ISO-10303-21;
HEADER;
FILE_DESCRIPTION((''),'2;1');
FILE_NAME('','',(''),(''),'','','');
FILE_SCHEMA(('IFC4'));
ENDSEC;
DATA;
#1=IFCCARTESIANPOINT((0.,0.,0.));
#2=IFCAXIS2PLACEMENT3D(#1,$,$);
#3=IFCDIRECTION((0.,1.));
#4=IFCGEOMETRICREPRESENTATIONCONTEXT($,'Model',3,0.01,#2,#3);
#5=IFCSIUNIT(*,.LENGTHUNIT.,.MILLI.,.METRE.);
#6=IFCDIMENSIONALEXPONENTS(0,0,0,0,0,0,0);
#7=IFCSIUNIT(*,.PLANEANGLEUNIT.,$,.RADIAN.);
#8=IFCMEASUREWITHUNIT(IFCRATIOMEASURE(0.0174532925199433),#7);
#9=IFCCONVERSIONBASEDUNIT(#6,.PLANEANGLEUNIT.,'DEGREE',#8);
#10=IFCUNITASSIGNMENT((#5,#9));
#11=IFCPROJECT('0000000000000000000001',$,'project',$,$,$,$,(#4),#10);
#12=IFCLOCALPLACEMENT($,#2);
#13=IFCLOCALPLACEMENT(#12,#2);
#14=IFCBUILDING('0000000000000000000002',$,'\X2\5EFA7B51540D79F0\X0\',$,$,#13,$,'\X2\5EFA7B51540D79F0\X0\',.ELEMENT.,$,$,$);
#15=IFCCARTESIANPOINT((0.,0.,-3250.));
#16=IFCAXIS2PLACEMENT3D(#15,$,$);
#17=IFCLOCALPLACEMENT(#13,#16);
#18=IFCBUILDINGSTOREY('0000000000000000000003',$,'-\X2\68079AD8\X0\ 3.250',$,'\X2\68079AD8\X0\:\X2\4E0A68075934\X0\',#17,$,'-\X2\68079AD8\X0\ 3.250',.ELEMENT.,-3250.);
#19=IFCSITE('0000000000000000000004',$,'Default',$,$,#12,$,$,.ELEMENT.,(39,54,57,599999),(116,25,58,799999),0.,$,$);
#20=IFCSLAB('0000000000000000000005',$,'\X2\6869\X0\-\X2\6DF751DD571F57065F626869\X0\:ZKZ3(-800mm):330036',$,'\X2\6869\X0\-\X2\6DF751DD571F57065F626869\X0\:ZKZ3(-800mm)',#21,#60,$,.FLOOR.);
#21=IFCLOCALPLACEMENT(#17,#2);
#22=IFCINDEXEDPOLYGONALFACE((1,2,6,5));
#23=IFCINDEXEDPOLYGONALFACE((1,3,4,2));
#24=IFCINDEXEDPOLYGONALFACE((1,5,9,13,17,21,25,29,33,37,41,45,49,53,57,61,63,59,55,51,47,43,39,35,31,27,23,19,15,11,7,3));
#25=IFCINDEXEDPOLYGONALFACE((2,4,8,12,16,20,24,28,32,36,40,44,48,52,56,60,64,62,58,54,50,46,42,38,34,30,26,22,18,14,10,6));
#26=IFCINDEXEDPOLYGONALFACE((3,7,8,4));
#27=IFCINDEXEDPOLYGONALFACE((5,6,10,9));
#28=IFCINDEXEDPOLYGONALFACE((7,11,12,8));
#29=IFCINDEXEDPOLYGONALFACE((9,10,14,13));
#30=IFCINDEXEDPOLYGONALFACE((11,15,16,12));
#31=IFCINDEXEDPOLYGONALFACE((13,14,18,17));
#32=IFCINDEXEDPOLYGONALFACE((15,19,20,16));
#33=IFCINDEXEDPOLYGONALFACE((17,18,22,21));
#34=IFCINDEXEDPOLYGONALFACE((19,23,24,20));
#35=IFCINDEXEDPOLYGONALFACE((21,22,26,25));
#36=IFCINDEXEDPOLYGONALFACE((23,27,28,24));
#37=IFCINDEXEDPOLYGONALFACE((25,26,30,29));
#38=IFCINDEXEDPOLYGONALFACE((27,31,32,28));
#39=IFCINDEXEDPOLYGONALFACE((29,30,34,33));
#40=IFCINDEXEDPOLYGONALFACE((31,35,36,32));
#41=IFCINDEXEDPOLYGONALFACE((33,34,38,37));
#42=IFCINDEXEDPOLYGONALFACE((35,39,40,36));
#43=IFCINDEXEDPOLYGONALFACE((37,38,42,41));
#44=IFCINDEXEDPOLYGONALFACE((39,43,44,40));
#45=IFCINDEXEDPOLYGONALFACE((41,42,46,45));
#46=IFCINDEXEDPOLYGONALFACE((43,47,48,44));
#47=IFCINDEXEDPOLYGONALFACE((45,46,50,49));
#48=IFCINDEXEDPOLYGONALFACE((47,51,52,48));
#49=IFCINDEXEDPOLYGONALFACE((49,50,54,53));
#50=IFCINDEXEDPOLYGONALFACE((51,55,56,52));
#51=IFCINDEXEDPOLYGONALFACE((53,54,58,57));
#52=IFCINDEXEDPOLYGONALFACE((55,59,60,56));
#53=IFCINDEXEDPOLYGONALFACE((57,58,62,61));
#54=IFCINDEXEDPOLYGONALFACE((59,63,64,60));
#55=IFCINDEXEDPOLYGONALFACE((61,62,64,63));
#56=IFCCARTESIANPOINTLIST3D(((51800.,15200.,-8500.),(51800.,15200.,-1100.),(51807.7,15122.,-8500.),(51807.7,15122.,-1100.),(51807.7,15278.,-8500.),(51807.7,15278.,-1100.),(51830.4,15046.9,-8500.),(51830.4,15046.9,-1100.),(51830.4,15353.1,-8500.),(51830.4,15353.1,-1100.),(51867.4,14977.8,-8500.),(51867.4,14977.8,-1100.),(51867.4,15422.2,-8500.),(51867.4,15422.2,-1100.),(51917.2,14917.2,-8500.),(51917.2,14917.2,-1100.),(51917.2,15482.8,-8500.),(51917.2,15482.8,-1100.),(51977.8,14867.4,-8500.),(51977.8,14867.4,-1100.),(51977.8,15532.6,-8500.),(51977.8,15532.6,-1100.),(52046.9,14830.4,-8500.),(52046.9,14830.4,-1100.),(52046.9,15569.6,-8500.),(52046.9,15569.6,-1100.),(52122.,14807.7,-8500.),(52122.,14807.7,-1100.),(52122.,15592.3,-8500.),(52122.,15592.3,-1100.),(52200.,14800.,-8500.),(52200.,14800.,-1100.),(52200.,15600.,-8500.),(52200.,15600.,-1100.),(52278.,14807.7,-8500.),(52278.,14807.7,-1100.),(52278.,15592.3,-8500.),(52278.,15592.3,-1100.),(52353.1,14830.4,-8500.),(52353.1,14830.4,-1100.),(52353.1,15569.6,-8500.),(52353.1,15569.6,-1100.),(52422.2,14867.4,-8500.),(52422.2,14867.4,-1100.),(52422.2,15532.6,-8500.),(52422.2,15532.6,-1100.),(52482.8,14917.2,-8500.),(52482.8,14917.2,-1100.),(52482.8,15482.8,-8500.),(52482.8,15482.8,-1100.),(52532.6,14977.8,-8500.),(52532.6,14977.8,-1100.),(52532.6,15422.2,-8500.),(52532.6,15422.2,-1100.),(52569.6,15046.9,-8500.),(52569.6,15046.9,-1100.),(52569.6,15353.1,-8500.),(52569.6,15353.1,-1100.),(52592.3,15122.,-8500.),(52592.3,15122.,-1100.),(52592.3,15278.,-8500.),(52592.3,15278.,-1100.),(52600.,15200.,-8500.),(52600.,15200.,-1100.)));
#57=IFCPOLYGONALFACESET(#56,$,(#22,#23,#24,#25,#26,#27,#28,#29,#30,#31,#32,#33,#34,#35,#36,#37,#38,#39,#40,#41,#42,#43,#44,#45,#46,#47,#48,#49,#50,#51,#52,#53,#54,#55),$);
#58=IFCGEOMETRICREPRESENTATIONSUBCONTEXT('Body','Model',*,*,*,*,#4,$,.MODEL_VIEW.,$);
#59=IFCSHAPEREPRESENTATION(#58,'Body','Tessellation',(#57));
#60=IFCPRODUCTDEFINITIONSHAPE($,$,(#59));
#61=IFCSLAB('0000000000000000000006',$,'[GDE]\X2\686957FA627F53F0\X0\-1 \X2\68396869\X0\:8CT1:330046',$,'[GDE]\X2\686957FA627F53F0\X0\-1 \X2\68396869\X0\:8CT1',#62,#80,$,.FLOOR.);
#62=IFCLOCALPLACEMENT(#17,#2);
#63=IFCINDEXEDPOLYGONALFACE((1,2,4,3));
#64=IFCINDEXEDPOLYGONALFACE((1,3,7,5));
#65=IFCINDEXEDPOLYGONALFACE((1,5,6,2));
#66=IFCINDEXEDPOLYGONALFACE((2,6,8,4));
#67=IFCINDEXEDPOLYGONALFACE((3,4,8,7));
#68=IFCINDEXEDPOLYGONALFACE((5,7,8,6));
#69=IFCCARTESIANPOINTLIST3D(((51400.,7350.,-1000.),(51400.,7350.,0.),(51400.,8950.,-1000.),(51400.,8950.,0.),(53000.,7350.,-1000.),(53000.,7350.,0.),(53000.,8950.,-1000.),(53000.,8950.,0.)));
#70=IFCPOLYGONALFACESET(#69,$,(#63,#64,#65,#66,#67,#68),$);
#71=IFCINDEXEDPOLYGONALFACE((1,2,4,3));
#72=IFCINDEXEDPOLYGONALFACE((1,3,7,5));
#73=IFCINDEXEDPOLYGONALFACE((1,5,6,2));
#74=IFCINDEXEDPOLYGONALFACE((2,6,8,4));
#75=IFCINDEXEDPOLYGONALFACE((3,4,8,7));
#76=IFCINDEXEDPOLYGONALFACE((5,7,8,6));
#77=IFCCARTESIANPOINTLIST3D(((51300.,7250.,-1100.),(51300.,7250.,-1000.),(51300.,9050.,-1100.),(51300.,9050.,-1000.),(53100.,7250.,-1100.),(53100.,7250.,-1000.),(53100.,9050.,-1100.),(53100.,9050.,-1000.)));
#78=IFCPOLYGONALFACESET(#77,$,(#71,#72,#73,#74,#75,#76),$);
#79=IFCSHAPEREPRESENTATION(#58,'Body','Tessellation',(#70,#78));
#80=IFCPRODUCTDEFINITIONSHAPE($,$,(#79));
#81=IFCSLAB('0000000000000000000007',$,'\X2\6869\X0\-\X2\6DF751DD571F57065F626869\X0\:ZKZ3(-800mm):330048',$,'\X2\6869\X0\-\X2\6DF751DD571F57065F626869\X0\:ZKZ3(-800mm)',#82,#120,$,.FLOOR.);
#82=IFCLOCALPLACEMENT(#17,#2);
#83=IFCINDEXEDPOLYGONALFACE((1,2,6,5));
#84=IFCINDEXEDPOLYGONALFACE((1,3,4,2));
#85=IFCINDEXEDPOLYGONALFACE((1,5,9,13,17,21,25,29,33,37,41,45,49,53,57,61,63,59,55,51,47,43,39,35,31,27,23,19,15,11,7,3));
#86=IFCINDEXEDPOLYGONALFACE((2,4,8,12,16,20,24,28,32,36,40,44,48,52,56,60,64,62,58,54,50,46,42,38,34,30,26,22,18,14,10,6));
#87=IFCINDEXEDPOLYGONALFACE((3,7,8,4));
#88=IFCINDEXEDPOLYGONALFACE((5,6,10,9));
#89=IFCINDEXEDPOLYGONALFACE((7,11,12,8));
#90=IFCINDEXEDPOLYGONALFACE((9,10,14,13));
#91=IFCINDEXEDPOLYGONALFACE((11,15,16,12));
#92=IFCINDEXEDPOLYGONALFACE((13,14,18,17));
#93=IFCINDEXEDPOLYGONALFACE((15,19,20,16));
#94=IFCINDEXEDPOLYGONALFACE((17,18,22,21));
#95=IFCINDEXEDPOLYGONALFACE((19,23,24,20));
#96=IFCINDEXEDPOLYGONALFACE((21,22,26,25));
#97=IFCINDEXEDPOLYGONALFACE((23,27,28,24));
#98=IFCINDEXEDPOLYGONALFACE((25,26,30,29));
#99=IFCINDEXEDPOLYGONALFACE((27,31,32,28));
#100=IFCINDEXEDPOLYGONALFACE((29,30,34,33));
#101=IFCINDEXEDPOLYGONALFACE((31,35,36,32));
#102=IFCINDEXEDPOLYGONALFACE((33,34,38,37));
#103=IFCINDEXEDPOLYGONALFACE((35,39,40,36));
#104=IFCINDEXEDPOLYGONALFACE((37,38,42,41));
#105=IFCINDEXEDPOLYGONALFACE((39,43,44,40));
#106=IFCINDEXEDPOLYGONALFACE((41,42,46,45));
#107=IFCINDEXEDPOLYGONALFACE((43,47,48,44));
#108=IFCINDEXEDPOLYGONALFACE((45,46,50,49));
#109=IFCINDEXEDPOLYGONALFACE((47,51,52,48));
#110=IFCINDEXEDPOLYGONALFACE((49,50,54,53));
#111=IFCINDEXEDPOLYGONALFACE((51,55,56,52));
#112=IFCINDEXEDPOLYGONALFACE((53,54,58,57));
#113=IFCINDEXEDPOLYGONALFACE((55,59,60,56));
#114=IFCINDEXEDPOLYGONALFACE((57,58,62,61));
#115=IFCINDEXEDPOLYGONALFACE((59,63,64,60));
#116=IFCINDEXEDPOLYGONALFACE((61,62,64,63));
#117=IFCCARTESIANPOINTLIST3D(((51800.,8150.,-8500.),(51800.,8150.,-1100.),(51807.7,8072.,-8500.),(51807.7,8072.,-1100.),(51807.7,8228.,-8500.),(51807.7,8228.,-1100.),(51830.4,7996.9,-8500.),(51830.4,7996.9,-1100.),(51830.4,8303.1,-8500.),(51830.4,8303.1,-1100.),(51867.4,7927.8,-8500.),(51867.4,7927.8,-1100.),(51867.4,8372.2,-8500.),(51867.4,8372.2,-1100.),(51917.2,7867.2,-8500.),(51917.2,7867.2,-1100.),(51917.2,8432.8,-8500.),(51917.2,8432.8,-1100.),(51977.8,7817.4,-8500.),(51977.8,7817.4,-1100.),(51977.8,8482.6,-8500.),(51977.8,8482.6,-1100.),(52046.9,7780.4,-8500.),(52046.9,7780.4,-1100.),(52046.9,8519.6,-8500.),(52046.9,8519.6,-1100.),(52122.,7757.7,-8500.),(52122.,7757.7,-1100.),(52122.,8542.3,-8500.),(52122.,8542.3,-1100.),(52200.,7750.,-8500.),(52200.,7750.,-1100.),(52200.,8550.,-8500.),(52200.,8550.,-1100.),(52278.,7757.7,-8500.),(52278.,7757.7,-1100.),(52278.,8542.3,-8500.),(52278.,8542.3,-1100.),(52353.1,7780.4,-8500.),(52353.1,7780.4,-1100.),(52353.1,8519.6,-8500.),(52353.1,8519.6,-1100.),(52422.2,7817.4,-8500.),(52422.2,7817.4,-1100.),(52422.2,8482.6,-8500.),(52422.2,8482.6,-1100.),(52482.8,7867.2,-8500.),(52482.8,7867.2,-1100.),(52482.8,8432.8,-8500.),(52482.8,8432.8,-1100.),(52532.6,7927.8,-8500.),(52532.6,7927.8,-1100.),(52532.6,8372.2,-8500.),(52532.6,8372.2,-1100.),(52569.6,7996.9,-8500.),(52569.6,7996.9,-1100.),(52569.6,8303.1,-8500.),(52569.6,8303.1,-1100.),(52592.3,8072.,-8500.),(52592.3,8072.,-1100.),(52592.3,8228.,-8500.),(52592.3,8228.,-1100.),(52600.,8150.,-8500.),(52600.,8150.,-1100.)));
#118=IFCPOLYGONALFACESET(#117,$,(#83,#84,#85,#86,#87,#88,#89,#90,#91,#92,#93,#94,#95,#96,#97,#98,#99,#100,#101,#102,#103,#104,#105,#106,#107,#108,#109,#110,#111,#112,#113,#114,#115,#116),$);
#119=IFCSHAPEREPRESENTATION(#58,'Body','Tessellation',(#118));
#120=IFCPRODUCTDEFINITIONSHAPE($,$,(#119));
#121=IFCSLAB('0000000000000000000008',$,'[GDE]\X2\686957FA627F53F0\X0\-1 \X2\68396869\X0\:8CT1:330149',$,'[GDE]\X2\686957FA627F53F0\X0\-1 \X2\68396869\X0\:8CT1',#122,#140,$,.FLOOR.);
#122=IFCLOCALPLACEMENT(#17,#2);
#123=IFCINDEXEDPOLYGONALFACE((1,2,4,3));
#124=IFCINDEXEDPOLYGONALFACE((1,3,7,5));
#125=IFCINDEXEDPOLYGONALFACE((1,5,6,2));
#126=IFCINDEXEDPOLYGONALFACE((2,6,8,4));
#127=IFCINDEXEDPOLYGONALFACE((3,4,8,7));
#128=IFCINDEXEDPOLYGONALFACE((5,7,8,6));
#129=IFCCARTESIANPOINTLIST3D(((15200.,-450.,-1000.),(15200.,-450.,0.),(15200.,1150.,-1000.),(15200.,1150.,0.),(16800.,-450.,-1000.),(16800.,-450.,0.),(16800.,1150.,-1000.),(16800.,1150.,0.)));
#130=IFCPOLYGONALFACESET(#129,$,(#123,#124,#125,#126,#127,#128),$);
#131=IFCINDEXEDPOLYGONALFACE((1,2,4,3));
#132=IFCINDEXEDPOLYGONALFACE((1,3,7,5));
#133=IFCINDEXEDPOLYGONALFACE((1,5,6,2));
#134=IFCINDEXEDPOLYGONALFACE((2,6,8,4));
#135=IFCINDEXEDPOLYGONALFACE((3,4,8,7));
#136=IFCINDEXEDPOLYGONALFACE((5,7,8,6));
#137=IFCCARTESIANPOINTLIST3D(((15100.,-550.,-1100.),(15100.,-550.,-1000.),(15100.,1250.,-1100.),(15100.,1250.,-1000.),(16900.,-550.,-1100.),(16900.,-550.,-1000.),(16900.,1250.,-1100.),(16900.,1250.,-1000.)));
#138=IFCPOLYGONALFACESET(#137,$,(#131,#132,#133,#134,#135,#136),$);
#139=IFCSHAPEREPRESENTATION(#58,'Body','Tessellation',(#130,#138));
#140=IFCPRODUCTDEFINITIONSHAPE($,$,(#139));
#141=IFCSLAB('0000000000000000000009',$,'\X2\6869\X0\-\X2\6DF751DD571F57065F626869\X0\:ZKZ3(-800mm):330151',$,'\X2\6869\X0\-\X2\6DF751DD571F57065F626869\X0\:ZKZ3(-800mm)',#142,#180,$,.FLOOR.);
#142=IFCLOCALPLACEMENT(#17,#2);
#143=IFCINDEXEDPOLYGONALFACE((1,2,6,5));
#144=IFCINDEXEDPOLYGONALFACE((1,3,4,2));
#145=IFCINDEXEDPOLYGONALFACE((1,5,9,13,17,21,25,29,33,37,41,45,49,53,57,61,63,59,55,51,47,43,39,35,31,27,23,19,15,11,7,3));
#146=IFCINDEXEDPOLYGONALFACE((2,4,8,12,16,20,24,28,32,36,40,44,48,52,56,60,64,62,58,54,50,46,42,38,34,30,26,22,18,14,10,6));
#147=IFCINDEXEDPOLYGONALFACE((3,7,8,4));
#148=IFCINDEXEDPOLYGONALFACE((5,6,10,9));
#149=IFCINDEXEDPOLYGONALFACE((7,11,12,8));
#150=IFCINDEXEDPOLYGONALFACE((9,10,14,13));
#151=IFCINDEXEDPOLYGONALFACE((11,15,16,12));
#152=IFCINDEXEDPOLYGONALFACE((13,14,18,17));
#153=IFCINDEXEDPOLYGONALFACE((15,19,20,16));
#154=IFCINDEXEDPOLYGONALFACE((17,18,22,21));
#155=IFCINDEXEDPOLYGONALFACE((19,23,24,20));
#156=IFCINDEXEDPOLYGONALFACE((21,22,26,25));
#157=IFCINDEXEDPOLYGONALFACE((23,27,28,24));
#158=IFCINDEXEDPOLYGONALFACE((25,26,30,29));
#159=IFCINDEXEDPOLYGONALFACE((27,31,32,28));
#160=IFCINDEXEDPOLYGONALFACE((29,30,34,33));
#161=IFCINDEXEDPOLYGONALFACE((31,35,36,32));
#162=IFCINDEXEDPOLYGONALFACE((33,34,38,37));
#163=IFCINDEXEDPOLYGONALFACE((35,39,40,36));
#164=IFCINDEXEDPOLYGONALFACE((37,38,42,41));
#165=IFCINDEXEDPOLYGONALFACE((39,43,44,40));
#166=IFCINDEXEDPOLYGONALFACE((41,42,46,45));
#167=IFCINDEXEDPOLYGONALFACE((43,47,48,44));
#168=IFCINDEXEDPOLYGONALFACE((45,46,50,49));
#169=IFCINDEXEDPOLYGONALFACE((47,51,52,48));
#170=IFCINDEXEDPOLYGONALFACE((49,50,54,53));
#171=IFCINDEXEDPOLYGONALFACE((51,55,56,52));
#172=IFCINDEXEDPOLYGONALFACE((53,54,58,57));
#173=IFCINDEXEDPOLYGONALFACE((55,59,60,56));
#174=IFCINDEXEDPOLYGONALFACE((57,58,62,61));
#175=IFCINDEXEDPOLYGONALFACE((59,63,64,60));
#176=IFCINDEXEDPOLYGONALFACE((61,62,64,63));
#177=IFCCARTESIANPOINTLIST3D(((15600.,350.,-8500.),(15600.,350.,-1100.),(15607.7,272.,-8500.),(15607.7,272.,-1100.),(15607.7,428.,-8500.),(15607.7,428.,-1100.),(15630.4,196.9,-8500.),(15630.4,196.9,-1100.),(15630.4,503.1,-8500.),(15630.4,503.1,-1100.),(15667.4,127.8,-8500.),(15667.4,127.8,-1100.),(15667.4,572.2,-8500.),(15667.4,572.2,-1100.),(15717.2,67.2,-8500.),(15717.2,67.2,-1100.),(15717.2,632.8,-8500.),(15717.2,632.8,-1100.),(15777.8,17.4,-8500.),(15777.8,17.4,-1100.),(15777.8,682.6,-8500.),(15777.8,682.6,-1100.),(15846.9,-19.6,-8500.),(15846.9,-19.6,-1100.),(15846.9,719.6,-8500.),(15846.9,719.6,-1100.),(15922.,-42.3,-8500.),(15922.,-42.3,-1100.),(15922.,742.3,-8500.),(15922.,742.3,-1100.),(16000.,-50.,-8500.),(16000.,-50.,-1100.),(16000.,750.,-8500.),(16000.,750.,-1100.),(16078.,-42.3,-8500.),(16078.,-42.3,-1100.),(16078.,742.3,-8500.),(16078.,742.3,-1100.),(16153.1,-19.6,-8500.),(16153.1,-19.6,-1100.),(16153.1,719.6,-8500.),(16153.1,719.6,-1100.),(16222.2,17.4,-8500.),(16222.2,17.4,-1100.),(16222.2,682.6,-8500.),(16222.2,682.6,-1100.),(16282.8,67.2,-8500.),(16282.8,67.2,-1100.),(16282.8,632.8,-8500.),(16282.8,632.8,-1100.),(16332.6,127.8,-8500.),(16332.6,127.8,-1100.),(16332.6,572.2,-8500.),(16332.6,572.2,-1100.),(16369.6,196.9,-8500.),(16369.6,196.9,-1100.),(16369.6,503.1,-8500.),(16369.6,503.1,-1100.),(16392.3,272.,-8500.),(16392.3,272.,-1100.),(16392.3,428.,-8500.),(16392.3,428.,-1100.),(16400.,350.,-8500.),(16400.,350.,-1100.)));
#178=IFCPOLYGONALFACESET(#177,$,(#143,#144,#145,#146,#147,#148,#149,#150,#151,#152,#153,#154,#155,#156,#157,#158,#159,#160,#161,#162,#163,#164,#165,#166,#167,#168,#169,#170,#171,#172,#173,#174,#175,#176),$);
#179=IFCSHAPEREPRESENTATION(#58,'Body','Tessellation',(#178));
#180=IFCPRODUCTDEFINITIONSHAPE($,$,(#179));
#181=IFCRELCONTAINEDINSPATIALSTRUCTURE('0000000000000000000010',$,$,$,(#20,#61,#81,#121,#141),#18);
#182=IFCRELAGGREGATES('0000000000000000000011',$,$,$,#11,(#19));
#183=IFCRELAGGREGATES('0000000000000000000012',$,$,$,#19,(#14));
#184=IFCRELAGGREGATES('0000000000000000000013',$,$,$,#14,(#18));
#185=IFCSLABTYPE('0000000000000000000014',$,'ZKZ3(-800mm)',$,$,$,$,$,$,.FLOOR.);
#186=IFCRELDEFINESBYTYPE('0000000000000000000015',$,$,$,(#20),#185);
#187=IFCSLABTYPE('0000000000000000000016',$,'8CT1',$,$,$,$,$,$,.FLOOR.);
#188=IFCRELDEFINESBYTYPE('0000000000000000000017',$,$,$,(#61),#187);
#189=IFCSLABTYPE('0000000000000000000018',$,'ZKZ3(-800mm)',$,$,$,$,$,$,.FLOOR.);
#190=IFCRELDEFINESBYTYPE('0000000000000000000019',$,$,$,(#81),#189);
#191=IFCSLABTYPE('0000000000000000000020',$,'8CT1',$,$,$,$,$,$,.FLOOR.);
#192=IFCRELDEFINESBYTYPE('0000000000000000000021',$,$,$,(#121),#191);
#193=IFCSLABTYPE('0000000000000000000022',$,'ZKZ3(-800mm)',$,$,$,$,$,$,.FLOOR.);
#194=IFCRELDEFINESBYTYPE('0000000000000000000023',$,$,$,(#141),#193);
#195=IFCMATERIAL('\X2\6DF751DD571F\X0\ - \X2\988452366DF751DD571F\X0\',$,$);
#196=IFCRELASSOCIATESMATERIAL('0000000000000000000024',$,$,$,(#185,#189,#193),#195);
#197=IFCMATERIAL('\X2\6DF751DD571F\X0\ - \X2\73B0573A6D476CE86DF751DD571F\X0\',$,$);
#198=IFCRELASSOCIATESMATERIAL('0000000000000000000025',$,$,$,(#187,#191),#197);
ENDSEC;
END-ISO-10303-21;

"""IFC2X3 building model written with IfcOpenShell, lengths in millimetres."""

from ifc_helpers import new_model, entity, si_unit, converted_unit, direction, frame, frame_2d, origin, origin_2d_with_axis, place, context, subcontext, project, spatial, rectangle, circle, extrude, material, type_object, element, save


model = new_model("IFC2X3")

# Units and contexts
model_context = context("Model", 3, precision=0.01, world=origin(), true_north=direction((0.0, 1.0)))
body_context = subcontext(model_context, "Body", "Model", "MODEL_VIEW")
ifc_project = project(units=[si_unit("LENGTHUNIT", "METRE", prefix="MILLI"), converted_unit("PLANEANGLEUNIT", "DEGREE", entity("IfcRatioMeasure", 0.0174532925199433), si_unit("PLANEANGLEUNIT", "RADIAN"), dimensions=[0, 0, 0, 0, 0, 0, 0])], contexts=[model_context])

# Site, building, storey
site_placement = place(None, origin())
site = spatial("IfcSite", under=ifc_project, at=site_placement, Name="Default", CompositionType="ELEMENT", RefLatitude=(39, 54, 57, 599999), RefLongitude=(116, 25, 58, 799999), RefElevation=0.0)
building_placement = place(site_placement, origin())
building = spatial("IfcBuilding", under=site, at=building_placement, Name="建筑名称", LongName="建筑名称", CompositionType="ELEMENT")
storey_placement = place(building_placement, frame((0.0, 0.0, -3250.0)))
storey = spatial("IfcBuildingStorey", under=building, at=storey_placement, Name="-标高 3.250", ObjectType="标高:上标头", LongName="-标高 3.250", CompositionType="ELEMENT", Elevation=-3250.0)

# Slabs
ifc_material_1 = material(Name="混凝土 - 现场浇注混凝土")
ifc_material_2 = material(Name="混凝土 - 预制混凝土")
slab_type_1 = type_object("IfcSlabType", Name="ZKZ3(-800mm)", PredefinedType="FLOOR", material=ifc_material_2)
slab_1_placement = place(storey_placement, origin())
element("IfcSlab", 1, at=slab_1_placement, inside=storey, type_object=slab_type_1, Name="桩-混凝土圆形桩:ZKZ3(-800mm):330036", ObjectType="桩-混凝土圆形桩:ZKZ3(-800mm)", PredefinedType="FLOOR", context=body_context, shape_type="SweptSolid", body=[
    extrude(circle(Radius=400.0, at=frame_2d((0.0, 0.0), x_axis=(1.0, 0.0))), frame((52200.0, 15200.0, -8500.0)), (0.0, 0.0, 1.0), 7400.0),
])
slab_type_2 = type_object("IfcSlabType", Name="8CT1", PredefinedType="FLOOR", material=ifc_material_1)
slab_2_placement = place(storey_placement, origin())
element("IfcSlab", 2, at=slab_2_placement, inside=storey, type_object=slab_type_2, Name="[GDE]桩基承台-1 根桩:8CT1:330046", ObjectType="[GDE]桩基承台-1 根桩:8CT1", PredefinedType="FLOOR", context=body_context, shape_type="SweptSolid", body=[
    extrude(rectangle(XDim=1600.0, YDim=1600.0, at=origin_2d_with_axis()), frame((52200.0, 8150.0, -1000.0), z_axis=(0.0, 0.0, 1.0), x_axis=(-1.0, 0.0, 0.0)), (0.0, 0.0, 1.0), 1000.0),
    extrude(rectangle(XDim=1800.0, YDim=1800.0, at=frame_2d((0.0, 0.0), x_axis=(1.0, 0.0))), frame((52200.0, 8150.0, -1100.0), z_axis=(0.0, 0.0, 1.0), x_axis=(-1.0, 0.0, 0.0)), (0.0, 0.0, 1.0), 100.0),
])
slab_type_3 = type_object("IfcSlabType", Name="ZKZ3(-800mm)", PredefinedType="FLOOR", material=ifc_material_2)
slab_3_placement = place(storey_placement, origin())
element("IfcSlab", 3, at=slab_3_placement, inside=storey, type_object=slab_type_3, Name="桩-混凝土圆形桩:ZKZ3(-800mm):330048", ObjectType="桩-混凝土圆形桩:ZKZ3(-800mm)", PredefinedType="FLOOR", context=body_context, shape_type="SweptSolid", body=[
    extrude(circle(Radius=400.0, at=origin_2d_with_axis()), frame((52200.0, 8150.0, -8500.0)), (0.0, 0.0, 1.0), 7400.0),
])
slab_type_4 = type_object("IfcSlabType", Name="8CT1", PredefinedType="FLOOR", material=ifc_material_1)
slab_4_placement = place(storey_placement, origin())
element("IfcSlab", 4, at=slab_4_placement, inside=storey, type_object=slab_type_4, Name="[GDE]桩基承台-1 根桩:8CT1:330149", ObjectType="[GDE]桩基承台-1 根桩:8CT1", PredefinedType="FLOOR", context=body_context, shape_type="SweptSolid", body=[
    extrude(rectangle(XDim=1600.0, YDim=1600.0, at=origin_2d_with_axis()), frame((16000.0, 350.0, -1000.0), z_axis=(0.0, 0.0, 1.0), x_axis=(-1.0, 0.0, 0.0)), (0.0, 0.0, 1.0), 1000.0),
    extrude(rectangle(XDim=1800.0, YDim=1800.0, at=origin_2d_with_axis()), frame((16000.0, 350.0, -1100.0), z_axis=(0.0, 0.0, 1.0), x_axis=(-1.0, 0.0, 0.0)), (0.0, 0.0, 1.0), 100.0),
])
slab_type_5 = type_object("IfcSlabType", Name="ZKZ3(-800mm)", PredefinedType="FLOOR", material=ifc_material_2)
slab_5_placement = place(storey_placement, origin())
element("IfcSlab", 5, at=slab_5_placement, inside=storey, type_object=slab_type_5, Name="桩-混凝土圆形桩:ZKZ3(-800mm):330151", ObjectType="桩-混凝土圆形桩:ZKZ3(-800mm)", PredefinedType="FLOOR", context=body_context, shape_type="SweptSolid", body=[
    extrude(circle(Radius=400.0, at=frame_2d((0.0, 0.0), x_axis=(1.0, 0.0))), frame((16000.0, 350.0, -8500.0)), (0.0, 0.0, 1.0), 7400.0),
])

save(model, "model.ifc")
